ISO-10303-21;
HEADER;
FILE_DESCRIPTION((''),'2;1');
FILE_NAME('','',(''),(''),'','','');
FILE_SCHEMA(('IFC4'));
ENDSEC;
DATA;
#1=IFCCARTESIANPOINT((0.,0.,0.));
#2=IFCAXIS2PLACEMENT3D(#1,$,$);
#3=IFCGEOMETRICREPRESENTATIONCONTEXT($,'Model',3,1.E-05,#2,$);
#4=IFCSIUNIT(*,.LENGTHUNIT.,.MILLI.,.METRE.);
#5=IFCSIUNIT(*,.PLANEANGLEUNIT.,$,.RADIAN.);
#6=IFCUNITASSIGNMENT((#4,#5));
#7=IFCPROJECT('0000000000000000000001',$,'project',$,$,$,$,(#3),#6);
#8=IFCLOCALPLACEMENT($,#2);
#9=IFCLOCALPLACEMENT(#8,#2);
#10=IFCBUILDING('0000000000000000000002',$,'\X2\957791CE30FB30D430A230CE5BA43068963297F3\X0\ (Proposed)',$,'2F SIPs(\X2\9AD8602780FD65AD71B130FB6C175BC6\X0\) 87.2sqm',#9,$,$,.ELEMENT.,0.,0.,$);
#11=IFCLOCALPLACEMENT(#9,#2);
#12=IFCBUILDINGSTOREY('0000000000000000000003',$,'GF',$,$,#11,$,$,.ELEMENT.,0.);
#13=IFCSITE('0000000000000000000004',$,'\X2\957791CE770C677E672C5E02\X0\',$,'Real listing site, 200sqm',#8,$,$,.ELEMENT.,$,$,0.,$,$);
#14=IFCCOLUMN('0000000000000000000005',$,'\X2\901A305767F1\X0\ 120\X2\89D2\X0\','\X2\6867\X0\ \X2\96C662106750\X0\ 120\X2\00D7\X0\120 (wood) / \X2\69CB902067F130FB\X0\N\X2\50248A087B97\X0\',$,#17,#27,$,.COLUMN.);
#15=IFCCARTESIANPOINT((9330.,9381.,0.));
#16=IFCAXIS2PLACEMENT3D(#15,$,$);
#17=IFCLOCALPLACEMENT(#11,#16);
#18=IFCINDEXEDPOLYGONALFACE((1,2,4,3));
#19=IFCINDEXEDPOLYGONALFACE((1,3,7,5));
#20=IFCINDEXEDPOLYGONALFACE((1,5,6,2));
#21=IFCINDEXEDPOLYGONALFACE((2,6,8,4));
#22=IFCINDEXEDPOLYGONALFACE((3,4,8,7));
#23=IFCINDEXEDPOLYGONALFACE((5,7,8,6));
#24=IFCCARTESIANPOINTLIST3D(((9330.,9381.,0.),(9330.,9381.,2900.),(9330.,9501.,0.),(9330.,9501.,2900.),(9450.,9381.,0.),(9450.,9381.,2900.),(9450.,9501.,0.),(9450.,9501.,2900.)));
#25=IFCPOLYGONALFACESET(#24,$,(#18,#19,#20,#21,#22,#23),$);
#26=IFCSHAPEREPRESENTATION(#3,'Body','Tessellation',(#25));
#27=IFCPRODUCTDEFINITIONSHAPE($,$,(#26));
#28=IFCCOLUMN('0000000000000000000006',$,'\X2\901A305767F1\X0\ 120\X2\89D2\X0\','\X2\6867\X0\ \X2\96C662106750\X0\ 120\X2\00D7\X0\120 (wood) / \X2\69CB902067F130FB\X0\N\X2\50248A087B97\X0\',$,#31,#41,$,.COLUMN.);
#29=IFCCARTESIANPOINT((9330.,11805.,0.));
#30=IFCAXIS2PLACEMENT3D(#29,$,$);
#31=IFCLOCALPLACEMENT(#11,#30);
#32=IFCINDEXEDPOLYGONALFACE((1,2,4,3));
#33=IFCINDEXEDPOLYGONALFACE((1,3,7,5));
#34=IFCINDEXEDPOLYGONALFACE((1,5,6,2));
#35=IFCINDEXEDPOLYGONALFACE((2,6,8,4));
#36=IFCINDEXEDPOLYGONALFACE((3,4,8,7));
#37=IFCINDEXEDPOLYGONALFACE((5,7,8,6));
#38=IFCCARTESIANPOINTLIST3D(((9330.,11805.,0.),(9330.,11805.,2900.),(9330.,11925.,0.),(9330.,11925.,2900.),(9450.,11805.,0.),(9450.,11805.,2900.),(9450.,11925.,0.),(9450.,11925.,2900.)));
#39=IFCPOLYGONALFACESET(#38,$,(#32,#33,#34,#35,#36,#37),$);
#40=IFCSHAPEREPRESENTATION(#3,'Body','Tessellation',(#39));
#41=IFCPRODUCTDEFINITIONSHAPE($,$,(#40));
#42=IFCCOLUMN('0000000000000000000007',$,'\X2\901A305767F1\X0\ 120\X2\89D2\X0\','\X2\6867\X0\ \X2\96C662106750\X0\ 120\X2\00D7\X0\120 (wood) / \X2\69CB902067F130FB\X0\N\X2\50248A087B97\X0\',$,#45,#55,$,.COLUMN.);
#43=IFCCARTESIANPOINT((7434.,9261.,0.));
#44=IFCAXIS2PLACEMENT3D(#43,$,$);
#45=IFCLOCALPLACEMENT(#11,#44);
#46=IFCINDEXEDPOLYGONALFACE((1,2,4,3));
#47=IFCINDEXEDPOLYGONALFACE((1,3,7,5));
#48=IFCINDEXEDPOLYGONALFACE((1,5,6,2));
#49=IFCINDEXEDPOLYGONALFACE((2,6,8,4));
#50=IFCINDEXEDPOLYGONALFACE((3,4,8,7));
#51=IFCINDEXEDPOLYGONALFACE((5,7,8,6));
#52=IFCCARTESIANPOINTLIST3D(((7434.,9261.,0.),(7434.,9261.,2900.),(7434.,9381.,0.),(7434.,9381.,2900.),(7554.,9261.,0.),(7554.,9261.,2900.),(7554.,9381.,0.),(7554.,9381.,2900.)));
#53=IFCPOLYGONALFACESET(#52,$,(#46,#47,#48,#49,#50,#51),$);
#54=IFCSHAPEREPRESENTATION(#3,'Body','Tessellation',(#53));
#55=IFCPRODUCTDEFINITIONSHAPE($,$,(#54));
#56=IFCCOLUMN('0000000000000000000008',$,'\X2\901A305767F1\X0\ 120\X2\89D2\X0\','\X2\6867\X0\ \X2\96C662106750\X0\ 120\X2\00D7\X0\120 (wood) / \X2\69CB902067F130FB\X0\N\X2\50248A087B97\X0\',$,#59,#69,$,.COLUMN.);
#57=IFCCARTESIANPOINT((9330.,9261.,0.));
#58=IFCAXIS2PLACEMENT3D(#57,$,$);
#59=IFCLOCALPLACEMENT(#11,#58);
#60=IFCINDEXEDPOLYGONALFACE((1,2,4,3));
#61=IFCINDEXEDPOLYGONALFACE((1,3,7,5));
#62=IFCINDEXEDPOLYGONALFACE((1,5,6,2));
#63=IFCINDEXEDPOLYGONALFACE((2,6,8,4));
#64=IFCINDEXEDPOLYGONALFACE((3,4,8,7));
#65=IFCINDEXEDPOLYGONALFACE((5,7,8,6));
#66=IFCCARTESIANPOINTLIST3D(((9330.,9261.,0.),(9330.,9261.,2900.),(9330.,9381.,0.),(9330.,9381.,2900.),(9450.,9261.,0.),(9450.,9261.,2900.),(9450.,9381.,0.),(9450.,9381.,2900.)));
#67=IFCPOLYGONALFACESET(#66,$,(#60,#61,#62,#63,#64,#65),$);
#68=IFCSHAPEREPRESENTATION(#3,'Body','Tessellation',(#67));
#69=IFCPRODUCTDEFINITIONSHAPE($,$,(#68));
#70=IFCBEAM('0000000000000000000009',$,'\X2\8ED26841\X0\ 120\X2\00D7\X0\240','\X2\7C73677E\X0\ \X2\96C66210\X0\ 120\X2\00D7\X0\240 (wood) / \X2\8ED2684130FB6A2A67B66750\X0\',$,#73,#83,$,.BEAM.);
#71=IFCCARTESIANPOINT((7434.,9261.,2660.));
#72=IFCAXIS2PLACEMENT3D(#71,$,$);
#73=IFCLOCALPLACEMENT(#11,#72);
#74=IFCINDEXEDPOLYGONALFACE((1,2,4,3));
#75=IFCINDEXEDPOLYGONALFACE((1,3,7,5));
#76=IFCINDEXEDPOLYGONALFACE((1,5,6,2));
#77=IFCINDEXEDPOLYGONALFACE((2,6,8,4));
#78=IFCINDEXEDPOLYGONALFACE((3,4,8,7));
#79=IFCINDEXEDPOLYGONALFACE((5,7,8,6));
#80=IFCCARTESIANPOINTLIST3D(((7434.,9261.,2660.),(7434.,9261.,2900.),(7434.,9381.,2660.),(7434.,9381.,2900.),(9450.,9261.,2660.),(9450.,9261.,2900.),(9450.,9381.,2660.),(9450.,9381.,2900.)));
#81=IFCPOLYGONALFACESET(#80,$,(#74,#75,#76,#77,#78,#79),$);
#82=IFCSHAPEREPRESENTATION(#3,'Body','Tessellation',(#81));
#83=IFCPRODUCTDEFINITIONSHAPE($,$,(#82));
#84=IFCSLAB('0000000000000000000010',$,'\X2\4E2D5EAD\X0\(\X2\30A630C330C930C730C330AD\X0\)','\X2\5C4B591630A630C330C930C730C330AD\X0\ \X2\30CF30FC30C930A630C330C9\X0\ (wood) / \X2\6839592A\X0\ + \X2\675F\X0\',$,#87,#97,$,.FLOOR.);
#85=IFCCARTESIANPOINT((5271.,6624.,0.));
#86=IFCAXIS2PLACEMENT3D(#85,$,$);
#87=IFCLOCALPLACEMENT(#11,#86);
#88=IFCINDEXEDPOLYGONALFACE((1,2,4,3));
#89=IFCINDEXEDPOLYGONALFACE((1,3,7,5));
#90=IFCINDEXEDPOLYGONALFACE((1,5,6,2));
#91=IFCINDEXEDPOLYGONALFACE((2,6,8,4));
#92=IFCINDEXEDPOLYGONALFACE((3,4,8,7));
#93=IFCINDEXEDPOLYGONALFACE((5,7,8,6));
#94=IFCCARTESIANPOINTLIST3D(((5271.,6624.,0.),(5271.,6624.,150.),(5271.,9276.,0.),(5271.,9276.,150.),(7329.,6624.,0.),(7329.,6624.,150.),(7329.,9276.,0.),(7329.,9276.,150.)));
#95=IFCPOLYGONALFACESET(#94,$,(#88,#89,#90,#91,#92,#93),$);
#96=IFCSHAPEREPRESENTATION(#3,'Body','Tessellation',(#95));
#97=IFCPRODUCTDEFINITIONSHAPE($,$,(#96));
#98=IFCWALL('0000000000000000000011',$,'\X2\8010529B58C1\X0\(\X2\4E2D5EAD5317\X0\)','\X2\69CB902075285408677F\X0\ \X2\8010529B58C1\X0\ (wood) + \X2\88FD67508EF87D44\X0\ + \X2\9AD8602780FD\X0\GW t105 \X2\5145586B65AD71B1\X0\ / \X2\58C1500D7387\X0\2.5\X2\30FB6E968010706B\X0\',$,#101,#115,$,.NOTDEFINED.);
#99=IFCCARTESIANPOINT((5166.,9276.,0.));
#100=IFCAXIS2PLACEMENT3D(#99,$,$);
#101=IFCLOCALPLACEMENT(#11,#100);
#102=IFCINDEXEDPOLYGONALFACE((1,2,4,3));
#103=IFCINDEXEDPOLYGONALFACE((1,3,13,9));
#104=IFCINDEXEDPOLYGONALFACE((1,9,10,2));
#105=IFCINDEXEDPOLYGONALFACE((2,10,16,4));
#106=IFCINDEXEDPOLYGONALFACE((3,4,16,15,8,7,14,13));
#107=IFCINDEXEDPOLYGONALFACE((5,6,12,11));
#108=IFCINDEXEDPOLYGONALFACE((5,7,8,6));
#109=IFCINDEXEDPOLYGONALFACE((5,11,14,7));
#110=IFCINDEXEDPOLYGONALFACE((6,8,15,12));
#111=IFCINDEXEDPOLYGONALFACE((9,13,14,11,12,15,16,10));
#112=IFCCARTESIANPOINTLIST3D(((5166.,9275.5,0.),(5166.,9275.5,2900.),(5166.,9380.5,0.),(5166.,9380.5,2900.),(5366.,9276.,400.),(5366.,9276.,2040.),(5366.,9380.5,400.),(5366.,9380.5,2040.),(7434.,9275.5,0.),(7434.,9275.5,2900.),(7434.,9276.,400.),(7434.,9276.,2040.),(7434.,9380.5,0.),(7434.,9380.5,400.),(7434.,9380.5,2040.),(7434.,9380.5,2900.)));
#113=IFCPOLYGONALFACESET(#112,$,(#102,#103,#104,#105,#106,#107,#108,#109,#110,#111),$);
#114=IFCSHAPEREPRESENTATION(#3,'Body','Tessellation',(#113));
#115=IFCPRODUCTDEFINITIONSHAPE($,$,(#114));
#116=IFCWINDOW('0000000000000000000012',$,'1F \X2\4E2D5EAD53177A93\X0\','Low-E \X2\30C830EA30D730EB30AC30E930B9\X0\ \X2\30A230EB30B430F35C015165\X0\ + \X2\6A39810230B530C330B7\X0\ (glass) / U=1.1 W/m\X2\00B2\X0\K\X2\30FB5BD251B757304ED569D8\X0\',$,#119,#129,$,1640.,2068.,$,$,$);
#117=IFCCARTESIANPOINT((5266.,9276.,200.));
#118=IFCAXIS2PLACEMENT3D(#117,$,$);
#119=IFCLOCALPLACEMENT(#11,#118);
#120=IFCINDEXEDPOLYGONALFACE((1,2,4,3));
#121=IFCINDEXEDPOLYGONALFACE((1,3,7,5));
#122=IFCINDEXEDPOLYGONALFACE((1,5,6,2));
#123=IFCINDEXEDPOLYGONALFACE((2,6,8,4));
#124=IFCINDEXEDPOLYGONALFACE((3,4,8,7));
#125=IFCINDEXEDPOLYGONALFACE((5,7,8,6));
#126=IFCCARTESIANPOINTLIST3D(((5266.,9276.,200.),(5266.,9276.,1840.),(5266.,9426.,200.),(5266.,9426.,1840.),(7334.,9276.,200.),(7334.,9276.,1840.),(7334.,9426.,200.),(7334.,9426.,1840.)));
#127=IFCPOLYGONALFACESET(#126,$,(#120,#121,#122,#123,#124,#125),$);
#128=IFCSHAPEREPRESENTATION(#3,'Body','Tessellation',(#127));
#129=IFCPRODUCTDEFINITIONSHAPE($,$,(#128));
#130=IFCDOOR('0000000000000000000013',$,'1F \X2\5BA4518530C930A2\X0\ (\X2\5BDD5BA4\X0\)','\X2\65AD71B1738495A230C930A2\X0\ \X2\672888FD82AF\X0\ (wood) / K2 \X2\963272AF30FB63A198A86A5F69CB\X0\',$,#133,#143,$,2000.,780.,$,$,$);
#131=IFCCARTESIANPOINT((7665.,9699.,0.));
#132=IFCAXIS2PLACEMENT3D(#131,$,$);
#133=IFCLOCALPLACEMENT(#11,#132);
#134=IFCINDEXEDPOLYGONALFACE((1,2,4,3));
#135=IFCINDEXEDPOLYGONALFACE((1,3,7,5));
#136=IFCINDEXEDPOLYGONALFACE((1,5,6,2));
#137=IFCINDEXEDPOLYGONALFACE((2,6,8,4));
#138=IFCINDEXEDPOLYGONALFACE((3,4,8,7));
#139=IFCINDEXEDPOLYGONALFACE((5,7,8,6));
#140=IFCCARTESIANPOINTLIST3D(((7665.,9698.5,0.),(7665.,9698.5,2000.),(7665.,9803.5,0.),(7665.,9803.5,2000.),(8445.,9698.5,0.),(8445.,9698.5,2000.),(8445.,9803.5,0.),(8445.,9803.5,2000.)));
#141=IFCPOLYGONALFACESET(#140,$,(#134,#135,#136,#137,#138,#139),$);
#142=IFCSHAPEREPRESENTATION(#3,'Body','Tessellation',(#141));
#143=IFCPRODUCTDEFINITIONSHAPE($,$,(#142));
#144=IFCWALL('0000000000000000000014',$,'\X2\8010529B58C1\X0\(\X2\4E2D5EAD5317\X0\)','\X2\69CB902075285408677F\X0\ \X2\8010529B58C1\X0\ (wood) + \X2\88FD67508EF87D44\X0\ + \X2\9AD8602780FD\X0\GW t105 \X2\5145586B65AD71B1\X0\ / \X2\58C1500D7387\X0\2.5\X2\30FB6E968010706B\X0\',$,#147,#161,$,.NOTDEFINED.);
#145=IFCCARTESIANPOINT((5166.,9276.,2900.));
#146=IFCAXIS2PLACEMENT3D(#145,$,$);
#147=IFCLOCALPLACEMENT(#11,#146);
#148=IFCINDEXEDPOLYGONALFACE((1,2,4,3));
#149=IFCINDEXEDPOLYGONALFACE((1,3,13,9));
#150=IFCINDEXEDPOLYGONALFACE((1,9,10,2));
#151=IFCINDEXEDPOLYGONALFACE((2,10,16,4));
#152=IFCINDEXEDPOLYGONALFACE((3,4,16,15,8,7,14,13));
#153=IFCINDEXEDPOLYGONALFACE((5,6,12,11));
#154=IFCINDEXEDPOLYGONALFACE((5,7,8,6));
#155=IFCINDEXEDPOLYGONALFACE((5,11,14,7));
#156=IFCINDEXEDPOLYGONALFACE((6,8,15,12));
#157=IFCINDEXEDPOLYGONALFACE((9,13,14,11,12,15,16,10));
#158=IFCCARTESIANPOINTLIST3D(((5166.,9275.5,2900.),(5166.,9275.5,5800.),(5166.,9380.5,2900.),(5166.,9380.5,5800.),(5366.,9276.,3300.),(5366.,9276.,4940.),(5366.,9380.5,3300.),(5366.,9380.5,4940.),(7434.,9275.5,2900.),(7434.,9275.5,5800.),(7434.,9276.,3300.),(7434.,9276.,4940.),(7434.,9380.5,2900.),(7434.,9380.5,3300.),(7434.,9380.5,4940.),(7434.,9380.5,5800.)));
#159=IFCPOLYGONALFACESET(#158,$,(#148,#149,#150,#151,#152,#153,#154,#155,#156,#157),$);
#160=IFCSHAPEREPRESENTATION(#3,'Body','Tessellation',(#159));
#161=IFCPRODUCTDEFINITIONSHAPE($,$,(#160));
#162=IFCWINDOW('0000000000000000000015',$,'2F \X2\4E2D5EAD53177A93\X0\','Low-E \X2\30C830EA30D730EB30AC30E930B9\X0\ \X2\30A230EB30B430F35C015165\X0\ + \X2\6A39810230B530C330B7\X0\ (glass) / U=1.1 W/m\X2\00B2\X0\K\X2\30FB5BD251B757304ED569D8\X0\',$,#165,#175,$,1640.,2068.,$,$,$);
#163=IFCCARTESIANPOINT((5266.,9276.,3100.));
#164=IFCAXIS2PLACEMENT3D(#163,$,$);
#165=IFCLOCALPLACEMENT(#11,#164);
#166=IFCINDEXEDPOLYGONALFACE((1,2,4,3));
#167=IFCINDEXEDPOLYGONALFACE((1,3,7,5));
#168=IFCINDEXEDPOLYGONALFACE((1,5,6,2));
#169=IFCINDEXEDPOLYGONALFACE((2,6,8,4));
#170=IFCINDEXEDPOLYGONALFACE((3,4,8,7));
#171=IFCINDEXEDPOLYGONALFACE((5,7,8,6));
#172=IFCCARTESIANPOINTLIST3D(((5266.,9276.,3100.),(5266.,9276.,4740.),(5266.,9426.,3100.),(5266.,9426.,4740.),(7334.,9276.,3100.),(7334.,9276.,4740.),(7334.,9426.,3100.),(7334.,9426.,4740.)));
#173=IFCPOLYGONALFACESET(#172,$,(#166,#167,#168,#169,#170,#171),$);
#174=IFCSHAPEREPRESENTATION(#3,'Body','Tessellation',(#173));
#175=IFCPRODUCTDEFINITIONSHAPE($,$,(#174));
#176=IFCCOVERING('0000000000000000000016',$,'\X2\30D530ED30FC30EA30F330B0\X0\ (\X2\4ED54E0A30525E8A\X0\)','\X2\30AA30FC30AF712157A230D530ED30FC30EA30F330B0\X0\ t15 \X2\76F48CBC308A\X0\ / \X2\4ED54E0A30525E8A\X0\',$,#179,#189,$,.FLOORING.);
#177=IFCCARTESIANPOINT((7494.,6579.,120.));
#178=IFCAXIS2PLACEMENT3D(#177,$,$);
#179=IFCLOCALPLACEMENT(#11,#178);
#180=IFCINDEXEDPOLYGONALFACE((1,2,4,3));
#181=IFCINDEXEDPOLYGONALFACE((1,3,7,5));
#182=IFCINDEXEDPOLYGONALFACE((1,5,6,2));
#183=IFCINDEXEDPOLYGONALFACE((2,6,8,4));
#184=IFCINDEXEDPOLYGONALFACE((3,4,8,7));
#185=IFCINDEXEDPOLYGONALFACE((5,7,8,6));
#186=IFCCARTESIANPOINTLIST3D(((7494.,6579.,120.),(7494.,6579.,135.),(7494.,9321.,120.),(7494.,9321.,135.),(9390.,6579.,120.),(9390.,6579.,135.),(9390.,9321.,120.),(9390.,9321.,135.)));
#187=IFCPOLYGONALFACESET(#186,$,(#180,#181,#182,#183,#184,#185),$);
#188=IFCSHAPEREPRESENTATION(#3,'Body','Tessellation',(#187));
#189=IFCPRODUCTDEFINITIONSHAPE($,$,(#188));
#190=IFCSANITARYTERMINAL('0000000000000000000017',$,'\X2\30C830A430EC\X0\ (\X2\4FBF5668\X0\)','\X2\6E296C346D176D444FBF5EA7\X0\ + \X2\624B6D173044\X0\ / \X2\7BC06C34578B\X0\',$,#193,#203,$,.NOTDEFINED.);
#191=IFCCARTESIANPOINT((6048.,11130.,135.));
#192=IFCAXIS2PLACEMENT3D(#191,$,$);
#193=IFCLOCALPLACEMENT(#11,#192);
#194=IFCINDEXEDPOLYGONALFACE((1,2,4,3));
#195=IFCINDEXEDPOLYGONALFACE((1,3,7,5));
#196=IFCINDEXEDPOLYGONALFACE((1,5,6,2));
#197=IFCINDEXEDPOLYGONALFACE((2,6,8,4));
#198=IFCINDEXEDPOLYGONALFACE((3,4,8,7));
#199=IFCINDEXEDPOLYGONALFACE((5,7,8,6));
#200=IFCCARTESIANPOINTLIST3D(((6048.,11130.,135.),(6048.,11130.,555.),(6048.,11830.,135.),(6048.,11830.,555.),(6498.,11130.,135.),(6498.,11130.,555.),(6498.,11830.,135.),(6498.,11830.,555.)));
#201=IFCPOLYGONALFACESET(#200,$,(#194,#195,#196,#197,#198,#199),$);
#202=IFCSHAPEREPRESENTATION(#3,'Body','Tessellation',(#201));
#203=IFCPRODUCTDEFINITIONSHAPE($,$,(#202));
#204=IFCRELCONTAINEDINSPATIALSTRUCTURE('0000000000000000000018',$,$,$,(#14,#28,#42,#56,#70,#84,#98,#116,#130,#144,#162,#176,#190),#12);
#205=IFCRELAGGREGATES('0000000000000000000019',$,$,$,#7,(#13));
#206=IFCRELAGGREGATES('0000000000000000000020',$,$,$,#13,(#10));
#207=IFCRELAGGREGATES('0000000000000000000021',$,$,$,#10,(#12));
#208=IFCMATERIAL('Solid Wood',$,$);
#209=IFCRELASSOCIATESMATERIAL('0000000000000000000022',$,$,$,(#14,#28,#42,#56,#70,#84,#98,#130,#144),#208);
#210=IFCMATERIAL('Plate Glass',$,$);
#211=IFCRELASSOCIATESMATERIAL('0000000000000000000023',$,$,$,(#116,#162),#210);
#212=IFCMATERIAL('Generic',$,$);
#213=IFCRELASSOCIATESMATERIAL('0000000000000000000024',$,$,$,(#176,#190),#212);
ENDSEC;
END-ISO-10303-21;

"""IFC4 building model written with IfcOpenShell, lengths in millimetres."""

from ifc_helpers import new_model, si_unit, frame, frame_2d, origin, place, context, project, spatial, rectangle, extrude, material, element, fill, save


model = new_model("IFC4")

# Units and contexts
model_context = context("Model", 3, precision=1e-05, world=origin())
ifc_project = project(units=[si_unit("LENGTHUNIT", "METRE", prefix="MILLI"), si_unit("PLANEANGLEUNIT", "RADIAN")], contexts=[model_context])

# Site, building, storey
site_placement = place(None, origin())
site = spatial("IfcSite", under=ifc_project, at=site_placement, Name="長野県松本市", ObjectType="Real listing site, 200sqm", CompositionType="ELEMENT", RefElevation=0.0)
building_placement = place(site_placement, origin())
building = spatial("IfcBuilding", under=site, at=building_placement, Name="長野・ピアノ室と防音 (Proposed)", ObjectType="2F SIPs(高性能断熱・気密) 87.2sqm", CompositionType="ELEMENT", ElevationOfRefHeight=0.0, ElevationOfTerrain=0.0)
storey_placement = place(building_placement, origin())
storey = spatial("IfcBuildingStorey", under=building, at=storey_placement, Name="GF", CompositionType="ELEMENT", Elevation=0.0)

# Columns
ifc_material_1 = material(Name="Solid Wood")
column_1_placement = place(storey_placement, frame((9330.0, 9381.0, 0.0)))
element("IfcColumn", 1, at=column_1_placement, inside=storey, material=ifc_material_1, Name="通し柱 120角", Description="桧 集成材 120×120 (wood) / 構造柱・N値計算", PredefinedType="COLUMN", context=model_context, shape_type="SweptSolid", body=[
    extrude(rectangle(XDim=120.0, YDim=120.0, at=frame_2d((60.0, 60.0))), frame((9330.0, 9381.0, 0.0)), (0.0, 0.0, 1.0), 2900.0),
])
column_2_placement = place(storey_placement, frame((9330.0, 11805.0, 0.0)))
element("IfcColumn", 2, at=column_2_placement, inside=storey, material=ifc_material_1, Name="通し柱 120角", Description="桧 集成材 120×120 (wood) / 構造柱・N値計算", PredefinedType="COLUMN", context=model_context, shape_type="SweptSolid", body=[
    extrude(rectangle(XDim=120.0, YDim=120.0, at=frame_2d((60.0, 60.0))), frame((9330.0, 11805.0, 0.0)), (0.0, 0.0, 1.0), 2900.0),
])
column_3_placement = place(storey_placement, frame((7434.0, 9261.0, 0.0)))
element("IfcColumn", 3, at=column_3_placement, inside=storey, material=ifc_material_1, Name="通し柱 120角", Description="桧 集成材 120×120 (wood) / 構造柱・N値計算", PredefinedType="COLUMN", context=model_context, shape_type="SweptSolid", body=[
    extrude(rectangle(XDim=120.0, YDim=120.0, at=frame_2d((60.0, 60.0))), frame((7434.0, 9261.0, 0.0)), (0.0, 0.0, 1.0), 2900.0),
])
column_4_placement = place(storey_placement, frame((9330.0, 9261.0, 0.0)))
element("IfcColumn", 4, at=column_4_placement, inside=storey, material=ifc_material_1, Name="通し柱 120角", Description="桧 集成材 120×120 (wood) / 構造柱・N値計算", PredefinedType="COLUMN", context=model_context, shape_type="SweptSolid", body=[
    extrude(rectangle(XDim=120.0, YDim=120.0, at=frame_2d((60.0, 60.0))), frame((9330.0, 9261.0, 0.0)), (0.0, 0.0, 1.0), 2900.0),
])

# Beam
beam_1_placement = place(storey_placement, frame((7434.0, 9261.0, 2660.0)))
element("IfcBeam", 5, at=beam_1_placement, inside=storey, material=ifc_material_1, Name="軒桁 120×240", Description="米松 集成 120×240 (wood) / 軒桁・横架材", PredefinedType="BEAM", context=model_context, shape_type="SweptSolid", body=[
    extrude(rectangle(XDim=2016.0, YDim=120.0, at=frame_2d((1008.0, 60.0))), frame((7434.0, 9261.0, 2660.0)), (0.0, 0.0, 1.0), 240.0),
])

# Slab
slab_placement = place(storey_placement, frame((5271.0, 6624.0, 0.0)))
element("IfcSlab", 6, at=slab_placement, inside=storey, material=ifc_material_1, Name="中庭(ウッドデッキ)", Description="屋外ウッドデッキ ハードウッド (wood) / 根太 + 束", PredefinedType="FLOOR", context=model_context, shape_type="SweptSolid", body=[
    extrude(rectangle(XDim=2058.0, YDim=2652.0, at=frame_2d((1029.0, 1326.0))), frame((5271.0, 6624.0, 0.0)), (0.0, 0.0, 1.0), 150.0),
])

# Wall, opening, window
wall_1_placement = place(storey_placement, frame((5166.0, 9276.0, 0.0)))
wall_1 = element("IfcWall", 7, at=wall_1_placement, inside=storey, material=ifc_material_1, Name="耐力壁(中庭北)", Description="構造用合板 耐力壁 (wood) + 製材軸組 + 高性能GW t105 充填断熱 / 壁倍率2.5・準耐火", PredefinedType="NOTDEFINED", context=model_context, shape_type="SweptSolid", body=[
    extrude(rectangle(XDim=2268.0, YDim=105.0, at=frame_2d((1134.0, 52.0))), frame((5166.0, 9276.0, 0.0)), (0.0, 0.0, 1.0), 2900.0),
])
opening_1_placement = place(storey_placement, frame((5266.0, 9276.0, 200.0)))
opening_1 = element("IfcOpeningElement", 8, at=opening_1_placement, cuts=wall_1, PredefinedType="NOTDEFINED", context=model_context, shape_type="SweptSolid", body=[
    extrude(rectangle(XDim=2068.0, YDim=150.0, at=frame_2d((1034.0, 75.0))), frame((5266.0, 9276.0, 200.0)), (0.0, 0.0, 1.0), 1640.0),
])
ifc_material_2 = material(Name="Plate Glass")
window_1_placement = place(storey_placement, frame((5266.0, 9276.0, 200.0)))
window_1 = element("IfcWindow", 9, at=window_1_placement, inside=storey, material=ifc_material_2, Name="1F 中庭北窓", Description="Low-E トリプルガラス アルゴン封入 + 樹脂サッシ (glass) / U=1.1 W/m²K・寒冷地仕様", OverallHeight=1640.0, OverallWidth=2068.0, context=model_context, shape_type="SweptSolid", body=[
    extrude(rectangle(XDim=2068.0, YDim=150.0, at=frame_2d((1034.0, 75.0))), frame((5266.0, 9276.0, 200.0)), (0.0, 0.0, 1.0), 1640.0),
])
fill(opening_1, window_1)

# Door
door_placement = place(storey_placement, frame((7665.0, 9699.0, 0.0)))
element("IfcDoor", 10, at=door_placement, inside=storey, material=ifc_material_1, Name="1F 室内ドア (寝室)", Description="断熱玄関ドア 木製芯 (wood) / K2 防犯・採風機構", OverallHeight=2000.0, OverallWidth=780.0, context=model_context, shape_type="SweptSolid", body=[
    extrude(rectangle(XDim=780.0, YDim=105.0, at=frame_2d((390.0, 52.0))), frame((7665.0, 9699.0, 0.0)), (0.0, 0.0, 1.0), 2000.0),
])

# Wall, opening, window
wall_2_placement = place(storey_placement, frame((5166.0, 9276.0, 2900.0)))
wall_2 = element("IfcWall", 11, at=wall_2_placement, inside=storey, material=ifc_material_1, Name="耐力壁(中庭北)", Description="構造用合板 耐力壁 (wood) + 製材軸組 + 高性能GW t105 充填断熱 / 壁倍率2.5・準耐火", PredefinedType="NOTDEFINED", context=model_context, shape_type="SweptSolid", body=[
    extrude(rectangle(XDim=2268.0, YDim=105.0, at=frame_2d((1134.0, 52.0))), frame((5166.0, 9276.0, 2900.0)), (0.0, 0.0, 1.0), 2900.0),
])
opening_2_placement = place(storey_placement, frame((5266.0, 9276.0, 3100.0)))
opening_2 = element("IfcOpeningElement", 12, at=opening_2_placement, cuts=wall_2, PredefinedType="NOTDEFINED", context=model_context, shape_type="SweptSolid", body=[
    extrude(rectangle(XDim=2068.0, YDim=150.0, at=frame_2d((1034.0, 75.0))), frame((5266.0, 9276.0, 3100.0)), (0.0, 0.0, 1.0), 1640.0),
])
window_2_placement = place(storey_placement, frame((5266.0, 9276.0, 3100.0)))
window_2 = element("IfcWindow", 13, at=window_2_placement, inside=storey, material=ifc_material_2, Name="2F 中庭北窓", Description="Low-E トリプルガラス アルゴン封入 + 樹脂サッシ (glass) / U=1.1 W/m²K・寒冷地仕様", OverallHeight=1640.0, OverallWidth=2068.0, context=model_context, shape_type="SweptSolid", body=[
    extrude(rectangle(XDim=2068.0, YDim=150.0, at=frame_2d((1034.0, 75.0))), frame((5266.0, 9276.0, 3100.0)), (0.0, 0.0, 1.0), 1640.0),
])
fill(opening_2, window_2)

# Covering
ifc_material_3 = material(Name="Generic")
covering_placement = place(storey_placement, frame((7494.0, 6579.0, 120.0)))
element("IfcCovering", 14, at=covering_placement, inside=storey, material=ifc_material_3, Name="フローリング (仕上げ床)", Description="オーク無垢フローリング t15 直貼り / 仕上げ床", PredefinedType="FLOORING", context=model_context, shape_type="SweptSolid", body=[
    extrude(rectangle(XDim=1896.0, YDim=2742.0, at=frame_2d((948.0, 1371.0))), frame((7494.0, 6579.0, 120.0)), (0.0, 0.0, 1.0), 15.0),
])

# Sanitary terminal
sanitary_terminal_placement = place(storey_placement, frame((6048.0, 11130.0, 135.0)))
element("IfcSanitaryTerminal", 15, at=sanitary_terminal_placement, inside=storey, material=ifc_material_3, Name="トイレ (便器)", Description="温水洗浄便座 + 手洗い / 節水型", PredefinedType="NOTDEFINED", context=model_context, shape_type="SweptSolid", body=[
    extrude(rectangle(XDim=450.0, YDim=700.0, at=frame_2d((225.0, 350.0))), frame((6048.0, 11130.0, 135.0)), (0.0, 0.0, 1.0), 420.0),
])

save(model, "model.ifc")
